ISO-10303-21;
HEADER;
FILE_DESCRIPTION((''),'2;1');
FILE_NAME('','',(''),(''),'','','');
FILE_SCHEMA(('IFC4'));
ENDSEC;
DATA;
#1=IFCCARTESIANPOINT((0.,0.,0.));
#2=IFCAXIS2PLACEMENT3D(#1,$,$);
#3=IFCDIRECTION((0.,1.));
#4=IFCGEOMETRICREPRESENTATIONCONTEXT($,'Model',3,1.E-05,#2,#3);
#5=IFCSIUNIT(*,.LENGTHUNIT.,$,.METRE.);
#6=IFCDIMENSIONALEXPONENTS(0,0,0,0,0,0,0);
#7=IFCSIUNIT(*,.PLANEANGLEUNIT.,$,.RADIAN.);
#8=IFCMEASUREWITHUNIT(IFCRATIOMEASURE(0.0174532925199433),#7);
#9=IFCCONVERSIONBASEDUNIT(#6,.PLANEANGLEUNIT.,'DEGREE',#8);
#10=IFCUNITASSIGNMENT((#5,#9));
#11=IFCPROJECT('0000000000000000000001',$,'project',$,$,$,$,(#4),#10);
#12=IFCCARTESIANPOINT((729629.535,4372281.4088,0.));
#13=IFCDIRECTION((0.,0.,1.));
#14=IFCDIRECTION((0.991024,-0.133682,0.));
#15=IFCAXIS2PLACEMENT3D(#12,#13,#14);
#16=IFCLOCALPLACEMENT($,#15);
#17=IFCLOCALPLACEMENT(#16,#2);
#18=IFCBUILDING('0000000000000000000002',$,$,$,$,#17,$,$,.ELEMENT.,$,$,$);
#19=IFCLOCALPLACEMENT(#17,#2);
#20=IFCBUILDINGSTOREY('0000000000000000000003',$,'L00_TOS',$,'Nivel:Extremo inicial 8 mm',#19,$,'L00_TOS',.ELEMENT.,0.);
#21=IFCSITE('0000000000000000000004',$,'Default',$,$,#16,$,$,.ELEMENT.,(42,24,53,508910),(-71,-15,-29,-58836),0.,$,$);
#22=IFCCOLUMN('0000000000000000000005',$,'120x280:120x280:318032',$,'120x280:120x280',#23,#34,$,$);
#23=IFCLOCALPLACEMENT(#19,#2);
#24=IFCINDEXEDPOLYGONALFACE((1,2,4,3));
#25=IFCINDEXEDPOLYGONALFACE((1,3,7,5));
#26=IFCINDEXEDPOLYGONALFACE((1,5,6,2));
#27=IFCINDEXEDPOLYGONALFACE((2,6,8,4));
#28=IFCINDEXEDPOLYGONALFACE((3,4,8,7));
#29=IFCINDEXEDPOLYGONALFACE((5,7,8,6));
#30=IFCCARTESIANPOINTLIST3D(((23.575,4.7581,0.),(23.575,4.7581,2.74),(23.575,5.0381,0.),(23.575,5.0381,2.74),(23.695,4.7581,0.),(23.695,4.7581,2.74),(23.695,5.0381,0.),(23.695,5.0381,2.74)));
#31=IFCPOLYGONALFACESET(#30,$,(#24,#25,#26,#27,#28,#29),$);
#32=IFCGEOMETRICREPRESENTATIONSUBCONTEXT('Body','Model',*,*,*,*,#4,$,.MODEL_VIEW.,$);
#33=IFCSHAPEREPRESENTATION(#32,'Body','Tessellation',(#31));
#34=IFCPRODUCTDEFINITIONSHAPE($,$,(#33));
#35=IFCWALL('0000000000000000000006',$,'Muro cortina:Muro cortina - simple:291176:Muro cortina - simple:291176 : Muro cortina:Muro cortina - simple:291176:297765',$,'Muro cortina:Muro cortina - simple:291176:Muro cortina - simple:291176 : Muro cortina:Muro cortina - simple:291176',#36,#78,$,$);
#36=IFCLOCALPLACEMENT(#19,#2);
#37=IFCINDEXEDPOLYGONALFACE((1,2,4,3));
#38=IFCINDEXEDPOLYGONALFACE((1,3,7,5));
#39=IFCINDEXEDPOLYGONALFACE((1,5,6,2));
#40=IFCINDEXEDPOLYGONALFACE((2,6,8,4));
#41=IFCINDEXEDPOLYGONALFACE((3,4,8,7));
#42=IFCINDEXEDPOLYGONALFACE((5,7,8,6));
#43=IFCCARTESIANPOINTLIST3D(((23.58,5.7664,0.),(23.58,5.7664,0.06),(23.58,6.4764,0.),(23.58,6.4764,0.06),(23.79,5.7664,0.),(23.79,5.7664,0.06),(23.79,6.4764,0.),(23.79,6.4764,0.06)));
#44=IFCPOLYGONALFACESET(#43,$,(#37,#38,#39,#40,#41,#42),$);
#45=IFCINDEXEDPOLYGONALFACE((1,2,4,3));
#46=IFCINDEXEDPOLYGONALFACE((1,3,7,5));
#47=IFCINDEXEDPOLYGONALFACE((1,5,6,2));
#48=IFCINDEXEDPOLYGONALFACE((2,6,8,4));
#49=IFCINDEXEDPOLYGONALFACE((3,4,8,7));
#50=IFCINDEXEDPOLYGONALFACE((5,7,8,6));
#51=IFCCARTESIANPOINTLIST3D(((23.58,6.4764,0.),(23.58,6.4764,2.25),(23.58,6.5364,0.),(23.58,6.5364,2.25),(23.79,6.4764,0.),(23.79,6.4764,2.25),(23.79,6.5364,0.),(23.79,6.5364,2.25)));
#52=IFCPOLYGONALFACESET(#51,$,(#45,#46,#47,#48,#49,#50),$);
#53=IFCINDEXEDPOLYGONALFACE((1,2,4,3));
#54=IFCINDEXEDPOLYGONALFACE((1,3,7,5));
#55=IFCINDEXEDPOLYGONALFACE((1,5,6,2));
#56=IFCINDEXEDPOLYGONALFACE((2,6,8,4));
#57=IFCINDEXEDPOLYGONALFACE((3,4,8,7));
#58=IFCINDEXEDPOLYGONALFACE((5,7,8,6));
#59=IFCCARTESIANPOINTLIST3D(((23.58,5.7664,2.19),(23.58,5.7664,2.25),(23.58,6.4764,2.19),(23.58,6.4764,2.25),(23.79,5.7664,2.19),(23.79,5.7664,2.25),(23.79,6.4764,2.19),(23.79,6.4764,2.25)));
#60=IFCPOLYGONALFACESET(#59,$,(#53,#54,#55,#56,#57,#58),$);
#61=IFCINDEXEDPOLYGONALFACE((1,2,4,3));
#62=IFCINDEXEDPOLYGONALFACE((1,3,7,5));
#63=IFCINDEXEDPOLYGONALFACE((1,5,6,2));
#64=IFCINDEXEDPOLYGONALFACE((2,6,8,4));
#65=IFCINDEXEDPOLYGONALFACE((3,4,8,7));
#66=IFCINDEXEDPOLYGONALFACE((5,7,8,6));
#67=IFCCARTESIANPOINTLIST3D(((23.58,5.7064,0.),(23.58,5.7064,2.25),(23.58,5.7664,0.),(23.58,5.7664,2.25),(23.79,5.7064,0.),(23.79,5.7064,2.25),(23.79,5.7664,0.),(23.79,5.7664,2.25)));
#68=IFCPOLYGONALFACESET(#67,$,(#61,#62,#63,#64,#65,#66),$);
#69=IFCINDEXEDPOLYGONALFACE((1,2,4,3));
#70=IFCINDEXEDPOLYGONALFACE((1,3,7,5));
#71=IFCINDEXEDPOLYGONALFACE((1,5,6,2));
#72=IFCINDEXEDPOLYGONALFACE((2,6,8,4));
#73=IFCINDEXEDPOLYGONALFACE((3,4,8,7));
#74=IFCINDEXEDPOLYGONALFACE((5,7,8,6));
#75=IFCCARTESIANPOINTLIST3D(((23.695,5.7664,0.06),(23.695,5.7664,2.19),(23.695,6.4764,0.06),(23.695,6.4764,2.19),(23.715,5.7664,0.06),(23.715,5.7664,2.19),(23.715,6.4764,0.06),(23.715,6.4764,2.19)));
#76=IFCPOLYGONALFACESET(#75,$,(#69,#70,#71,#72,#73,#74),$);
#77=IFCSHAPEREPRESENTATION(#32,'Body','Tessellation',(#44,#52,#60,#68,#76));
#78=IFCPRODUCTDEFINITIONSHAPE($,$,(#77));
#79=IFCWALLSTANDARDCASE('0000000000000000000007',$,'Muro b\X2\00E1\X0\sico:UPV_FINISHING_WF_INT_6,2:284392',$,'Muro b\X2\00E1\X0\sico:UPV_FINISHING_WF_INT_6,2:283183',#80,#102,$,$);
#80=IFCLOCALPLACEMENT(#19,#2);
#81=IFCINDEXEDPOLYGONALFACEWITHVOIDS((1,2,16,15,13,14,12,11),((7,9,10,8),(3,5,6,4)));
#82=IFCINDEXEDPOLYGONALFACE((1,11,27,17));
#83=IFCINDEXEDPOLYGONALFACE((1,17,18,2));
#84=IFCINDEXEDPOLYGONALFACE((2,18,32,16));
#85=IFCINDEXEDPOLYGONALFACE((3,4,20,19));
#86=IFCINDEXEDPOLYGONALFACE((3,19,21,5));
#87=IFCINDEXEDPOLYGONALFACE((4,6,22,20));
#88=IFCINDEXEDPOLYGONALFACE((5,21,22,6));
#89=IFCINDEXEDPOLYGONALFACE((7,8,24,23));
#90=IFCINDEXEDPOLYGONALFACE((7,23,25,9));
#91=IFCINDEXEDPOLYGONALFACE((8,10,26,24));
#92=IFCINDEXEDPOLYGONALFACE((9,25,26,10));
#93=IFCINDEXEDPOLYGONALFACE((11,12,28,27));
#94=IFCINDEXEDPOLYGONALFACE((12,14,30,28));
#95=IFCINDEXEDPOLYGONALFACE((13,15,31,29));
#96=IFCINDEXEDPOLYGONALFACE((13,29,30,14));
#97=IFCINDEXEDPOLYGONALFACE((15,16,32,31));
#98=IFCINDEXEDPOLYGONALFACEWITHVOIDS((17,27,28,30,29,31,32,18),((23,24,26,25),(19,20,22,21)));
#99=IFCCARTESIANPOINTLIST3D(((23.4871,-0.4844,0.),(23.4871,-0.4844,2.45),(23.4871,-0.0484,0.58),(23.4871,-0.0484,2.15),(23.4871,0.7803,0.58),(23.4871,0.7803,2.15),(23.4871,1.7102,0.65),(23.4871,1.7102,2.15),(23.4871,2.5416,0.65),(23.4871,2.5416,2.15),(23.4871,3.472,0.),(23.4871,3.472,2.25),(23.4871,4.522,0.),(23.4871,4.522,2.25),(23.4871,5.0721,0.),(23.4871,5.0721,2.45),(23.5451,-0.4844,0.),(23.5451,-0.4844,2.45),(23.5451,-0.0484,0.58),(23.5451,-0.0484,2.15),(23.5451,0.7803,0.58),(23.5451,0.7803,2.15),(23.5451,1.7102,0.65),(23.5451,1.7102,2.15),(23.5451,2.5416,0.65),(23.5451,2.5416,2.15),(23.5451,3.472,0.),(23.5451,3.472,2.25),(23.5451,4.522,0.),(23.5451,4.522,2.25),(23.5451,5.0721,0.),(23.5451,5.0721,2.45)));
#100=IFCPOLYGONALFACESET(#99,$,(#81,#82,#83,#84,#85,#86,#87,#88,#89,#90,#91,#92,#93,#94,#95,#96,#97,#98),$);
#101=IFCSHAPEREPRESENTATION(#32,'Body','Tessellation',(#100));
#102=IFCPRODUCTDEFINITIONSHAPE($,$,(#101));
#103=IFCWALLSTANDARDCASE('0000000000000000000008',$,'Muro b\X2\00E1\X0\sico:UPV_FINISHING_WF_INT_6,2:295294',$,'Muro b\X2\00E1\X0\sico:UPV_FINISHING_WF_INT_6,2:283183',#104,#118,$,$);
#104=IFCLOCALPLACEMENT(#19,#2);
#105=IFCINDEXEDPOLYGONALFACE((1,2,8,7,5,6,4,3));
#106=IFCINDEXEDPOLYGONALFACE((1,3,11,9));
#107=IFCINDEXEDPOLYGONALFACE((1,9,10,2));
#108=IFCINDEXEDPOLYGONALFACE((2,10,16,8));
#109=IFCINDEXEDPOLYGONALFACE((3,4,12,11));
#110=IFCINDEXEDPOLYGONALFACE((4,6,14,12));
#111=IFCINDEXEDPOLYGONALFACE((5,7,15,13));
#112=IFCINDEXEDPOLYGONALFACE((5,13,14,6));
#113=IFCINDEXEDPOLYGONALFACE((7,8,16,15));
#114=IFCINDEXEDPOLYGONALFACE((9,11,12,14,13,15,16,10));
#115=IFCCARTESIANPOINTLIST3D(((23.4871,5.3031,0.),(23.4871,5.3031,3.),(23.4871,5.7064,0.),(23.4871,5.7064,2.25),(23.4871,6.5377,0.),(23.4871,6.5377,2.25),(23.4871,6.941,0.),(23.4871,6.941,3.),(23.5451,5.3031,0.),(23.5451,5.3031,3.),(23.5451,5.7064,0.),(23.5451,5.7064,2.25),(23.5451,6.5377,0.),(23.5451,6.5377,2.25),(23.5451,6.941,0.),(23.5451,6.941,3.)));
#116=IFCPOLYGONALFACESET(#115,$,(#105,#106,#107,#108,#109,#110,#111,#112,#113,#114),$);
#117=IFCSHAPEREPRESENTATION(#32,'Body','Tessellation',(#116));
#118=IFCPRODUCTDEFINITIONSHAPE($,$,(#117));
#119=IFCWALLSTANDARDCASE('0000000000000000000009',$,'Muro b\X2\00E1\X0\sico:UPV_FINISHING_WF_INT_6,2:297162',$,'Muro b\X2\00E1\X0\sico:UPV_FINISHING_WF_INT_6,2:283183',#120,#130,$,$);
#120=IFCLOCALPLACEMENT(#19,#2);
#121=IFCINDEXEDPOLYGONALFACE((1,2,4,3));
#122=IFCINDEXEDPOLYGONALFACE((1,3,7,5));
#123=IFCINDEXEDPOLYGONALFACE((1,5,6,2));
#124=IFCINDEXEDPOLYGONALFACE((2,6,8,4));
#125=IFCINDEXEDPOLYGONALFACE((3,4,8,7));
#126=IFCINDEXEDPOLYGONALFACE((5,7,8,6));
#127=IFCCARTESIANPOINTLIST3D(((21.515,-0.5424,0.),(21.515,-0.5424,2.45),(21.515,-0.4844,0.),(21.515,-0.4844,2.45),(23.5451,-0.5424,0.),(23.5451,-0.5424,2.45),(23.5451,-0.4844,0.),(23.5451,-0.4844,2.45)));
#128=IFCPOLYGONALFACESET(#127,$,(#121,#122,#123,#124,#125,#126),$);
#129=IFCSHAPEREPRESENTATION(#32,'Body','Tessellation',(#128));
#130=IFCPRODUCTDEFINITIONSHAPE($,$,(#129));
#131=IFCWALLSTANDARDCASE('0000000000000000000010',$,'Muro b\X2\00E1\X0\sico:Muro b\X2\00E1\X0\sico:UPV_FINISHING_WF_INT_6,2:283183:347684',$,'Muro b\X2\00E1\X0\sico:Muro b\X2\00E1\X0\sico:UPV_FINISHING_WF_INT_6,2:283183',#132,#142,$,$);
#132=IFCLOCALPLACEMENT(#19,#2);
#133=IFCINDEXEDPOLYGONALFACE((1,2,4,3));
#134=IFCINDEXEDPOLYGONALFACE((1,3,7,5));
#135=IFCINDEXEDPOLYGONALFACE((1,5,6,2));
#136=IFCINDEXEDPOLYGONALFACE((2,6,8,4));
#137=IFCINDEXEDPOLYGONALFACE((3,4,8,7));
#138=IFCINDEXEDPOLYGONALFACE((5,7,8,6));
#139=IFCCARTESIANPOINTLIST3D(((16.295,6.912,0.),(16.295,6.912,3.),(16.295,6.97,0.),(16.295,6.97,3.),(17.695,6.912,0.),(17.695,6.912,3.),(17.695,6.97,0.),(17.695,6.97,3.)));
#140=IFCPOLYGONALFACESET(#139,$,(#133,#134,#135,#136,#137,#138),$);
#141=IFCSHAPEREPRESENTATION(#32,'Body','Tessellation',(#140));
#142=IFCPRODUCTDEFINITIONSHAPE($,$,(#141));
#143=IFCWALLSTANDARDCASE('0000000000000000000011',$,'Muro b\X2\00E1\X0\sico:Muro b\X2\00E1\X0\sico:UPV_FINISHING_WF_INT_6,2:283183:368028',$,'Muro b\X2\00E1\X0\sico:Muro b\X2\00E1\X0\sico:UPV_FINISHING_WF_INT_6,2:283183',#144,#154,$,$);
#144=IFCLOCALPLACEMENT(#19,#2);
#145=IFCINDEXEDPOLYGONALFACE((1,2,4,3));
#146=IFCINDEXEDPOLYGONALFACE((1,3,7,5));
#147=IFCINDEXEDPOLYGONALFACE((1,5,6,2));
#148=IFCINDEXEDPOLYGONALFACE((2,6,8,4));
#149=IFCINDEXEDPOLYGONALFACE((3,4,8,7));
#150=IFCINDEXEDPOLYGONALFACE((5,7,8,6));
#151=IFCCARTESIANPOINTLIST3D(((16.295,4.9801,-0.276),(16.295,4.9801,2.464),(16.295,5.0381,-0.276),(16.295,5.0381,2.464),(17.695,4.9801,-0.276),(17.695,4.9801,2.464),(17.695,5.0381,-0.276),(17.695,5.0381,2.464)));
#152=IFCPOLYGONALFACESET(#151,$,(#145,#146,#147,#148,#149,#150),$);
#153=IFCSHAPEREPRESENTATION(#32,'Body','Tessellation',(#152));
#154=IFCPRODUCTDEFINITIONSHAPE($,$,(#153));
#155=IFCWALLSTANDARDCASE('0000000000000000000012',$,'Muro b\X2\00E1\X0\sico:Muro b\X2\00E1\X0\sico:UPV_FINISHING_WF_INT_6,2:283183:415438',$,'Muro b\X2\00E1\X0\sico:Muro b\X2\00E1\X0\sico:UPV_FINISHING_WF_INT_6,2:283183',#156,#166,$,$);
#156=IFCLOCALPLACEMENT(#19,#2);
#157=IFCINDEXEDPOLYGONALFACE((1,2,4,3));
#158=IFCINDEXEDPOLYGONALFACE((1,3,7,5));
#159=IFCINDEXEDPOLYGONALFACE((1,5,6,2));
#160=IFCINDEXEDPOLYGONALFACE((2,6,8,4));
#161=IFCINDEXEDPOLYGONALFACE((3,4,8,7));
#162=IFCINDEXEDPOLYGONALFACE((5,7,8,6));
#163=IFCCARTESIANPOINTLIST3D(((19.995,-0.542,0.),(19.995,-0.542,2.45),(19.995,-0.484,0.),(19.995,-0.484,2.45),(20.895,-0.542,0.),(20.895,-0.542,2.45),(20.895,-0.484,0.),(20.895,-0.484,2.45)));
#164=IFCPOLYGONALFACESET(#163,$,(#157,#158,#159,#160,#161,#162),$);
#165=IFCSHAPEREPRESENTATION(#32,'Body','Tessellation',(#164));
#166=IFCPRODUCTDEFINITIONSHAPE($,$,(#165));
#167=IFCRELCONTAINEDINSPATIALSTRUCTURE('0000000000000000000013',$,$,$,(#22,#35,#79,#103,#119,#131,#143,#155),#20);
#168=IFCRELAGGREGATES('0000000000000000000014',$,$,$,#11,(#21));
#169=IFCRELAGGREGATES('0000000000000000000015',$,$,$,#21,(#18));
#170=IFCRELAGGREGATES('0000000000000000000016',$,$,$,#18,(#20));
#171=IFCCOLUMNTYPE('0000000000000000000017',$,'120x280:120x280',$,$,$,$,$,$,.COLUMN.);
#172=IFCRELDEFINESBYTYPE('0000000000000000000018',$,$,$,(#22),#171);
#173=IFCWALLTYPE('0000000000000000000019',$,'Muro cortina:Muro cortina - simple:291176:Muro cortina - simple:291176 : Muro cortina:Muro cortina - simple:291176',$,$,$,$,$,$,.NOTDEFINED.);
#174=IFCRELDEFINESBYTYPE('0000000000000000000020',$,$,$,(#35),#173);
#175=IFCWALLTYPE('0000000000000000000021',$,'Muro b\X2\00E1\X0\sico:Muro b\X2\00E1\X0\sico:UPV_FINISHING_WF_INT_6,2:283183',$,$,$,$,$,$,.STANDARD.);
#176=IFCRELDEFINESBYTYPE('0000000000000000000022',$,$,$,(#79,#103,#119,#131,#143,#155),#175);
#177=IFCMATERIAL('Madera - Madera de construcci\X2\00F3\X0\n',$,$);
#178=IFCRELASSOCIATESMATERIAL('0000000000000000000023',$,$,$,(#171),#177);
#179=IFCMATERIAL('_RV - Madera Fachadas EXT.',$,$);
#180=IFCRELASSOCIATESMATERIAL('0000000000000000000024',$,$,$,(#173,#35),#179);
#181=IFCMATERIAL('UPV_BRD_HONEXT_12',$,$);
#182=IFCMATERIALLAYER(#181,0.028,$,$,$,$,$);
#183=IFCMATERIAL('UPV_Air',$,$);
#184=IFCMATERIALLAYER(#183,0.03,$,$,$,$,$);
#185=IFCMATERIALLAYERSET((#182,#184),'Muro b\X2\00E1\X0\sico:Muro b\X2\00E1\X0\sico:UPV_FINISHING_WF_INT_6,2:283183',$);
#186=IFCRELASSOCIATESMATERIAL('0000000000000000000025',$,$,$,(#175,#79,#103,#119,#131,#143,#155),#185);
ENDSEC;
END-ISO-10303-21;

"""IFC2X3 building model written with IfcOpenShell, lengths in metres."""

from ifc_helpers import new_model, entity, si_unit, converted_unit, direction, frame, frame_2d, origin, origin_2d_with_axis, place, context, subcontext, project, spatial, rectangle, extrude, source, transform, mapped, material, layer, layer_set, layer_usage, type_object, type_shapes, element, save


model = new_model("IFC2X3")

# Units and contexts
model_context = context("Model", 3, precision=1e-05, world=origin(), true_north=direction((0.0, 1.0)))
body_context = subcontext(model_context, "Body", "Model", "MODEL_VIEW")
ifc_project = project(units=[si_unit("LENGTHUNIT", "METRE"), converted_unit("PLANEANGLEUNIT", "DEGREE", entity("IfcRatioMeasure", 0.0174532925199433), si_unit("PLANEANGLEUNIT", "RADIAN"), dimensions=[0, 0, 0, 0, 0, 0, 0])], contexts=[model_context])

# Site, building, storey
site_placement = place(None, frame((729629.535, 4372281.4088, 0.0), z_axis=(0.0, 0.0, 1.0), x_axis=(0.991024, -0.133682, 0.0)))
site = spatial("IfcSite", under=ifc_project, at=site_placement, Name="Default", CompositionType="ELEMENT", RefLatitude=(42, 24, 53, 508910), RefLongitude=(-71, -15, -29, -58836), RefElevation=0.0)
building_placement = place(site_placement, origin())
building = spatial("IfcBuilding", under=site, at=building_placement, CompositionType="ELEMENT")
storey_placement = place(building_placement, origin())
storey = spatial("IfcBuildingStorey", under=building, at=storey_placement, Name="L00_TOS", ObjectType="Nivel:Extremo inicial 8 mm", LongName="L00_TOS", CompositionType="ELEMENT", Elevation=0.0)

# Column
ifc_material_1 = material(Name="Madera - Madera de construcción")
column_type = type_object("IfcColumnType", Name="120x280:120x280", PredefinedType="COLUMN", material=ifc_material_1)
shared_shape_1 = source(origin(), body_context, "Body", "SweptSolid", [
    extrude(rectangle(XDim=0.28, YDim=0.12, at=origin_2d_with_axis()), frame((0.0, 0.0, 0.0), z_axis=(0.0, 0.0, 1.0), x_axis=(0.0, -1.0, 0.0)), (0.0, 0.0, 1.0), 2.74),
])
type_shapes(column_type, [shared_shape_1])
column_placement = place(storey_placement, frame((23.635, 4.8981, 0.0)))
element("IfcColumn", 1, at=column_placement, inside=storey, type_object=column_type, Name="120x280:120x280:318032", ObjectType="120x280:120x280", context=body_context, shape_type="MappedRepresentation", body=[
    mapped(shared_shape_1, transform((0.0, 0.0, 0.0), scale=1.0)),
])

# Wall
ifc_material_2 = material(Name="_RV - Madera Fachadas EXT.")
wall_type_1 = type_object("IfcWallType", Name="Muro cortina:Muro cortina - simple:291176:Muro cortina - simple:291176 : Muro cortina:Muro cortina - simple:291176", PredefinedType="NOTDEFINED", material=ifc_material_2)
wall_1_placement = place(storey_placement, frame((23.58, 5.7064, 0.0), z_axis=(0.0, 0.0, 1.0), x_axis=(0.0, 1.0, 0.0)))
element("IfcWall", 2, at=wall_1_placement, inside=storey, type_object=wall_type_1, material=ifc_material_2, Name="Muro cortina:Muro cortina - simple:291176:Muro cortina - simple:291176 : Muro cortina:Muro cortina - simple:291176:297765", ObjectType="Muro cortina:Muro cortina - simple:291176:Muro cortina - simple:291176 : Muro cortina:Muro cortina - simple:291176", context=body_context, shape_type="SweptSolid", body=[
    extrude(rectangle(XDim=0.71, YDim=0.21, at=frame_2d((0.0, 0.0), x_axis=(1.0, 0.0))), frame((0.415, -0.105, 0.0), z_axis=(0.0, 0.0, 1.0), x_axis=(-1.0, 0.0, 0.0)), (0.0, 0.0, 1.0), 0.06),
    extrude(rectangle(XDim=0.06, YDim=0.21, at=frame_2d((0.0, 0.0), x_axis=(1.0, 0.0))), frame((0.8, -0.105, 0.0)), (0.0, 0.0, 1.0), 2.25),
    extrude(rectangle(XDim=0.71, YDim=0.21, at=frame_2d((0.0, 0.0), x_axis=(1.0, 0.0))), frame((0.415, -0.105, 2.19)), (0.0, 0.0, 1.0), 0.06),
    extrude(rectangle(XDim=0.21, YDim=0.06, at=frame_2d((0.0, 0.0), x_axis=(1.0, 0.0))), frame((0.03, -0.105, 0.0), z_axis=(0.0, 0.0, 1.0), x_axis=(0.0, 1.0, 0.0)), (0.0, 0.0, 1.0), 2.25),
    extrude(rectangle(XDim=0.71, YDim=0.02, at=frame_2d((0.0, 0.0), x_axis=(1.0, 0.0))), frame((0.415, -0.125, 0.06)), (0.0, 0.0, 1.0), 2.13),
])

# Wall, openings
ifc_material_3 = material(Name="UPV_BRD_HONEXT_12")
ifc_layer_1 = layer(ifc_material_3, 0.028)
ifc_material_4 = material(Name="UPV_Air")
ifc_layer_2 = layer(ifc_material_4, 0.03)
ifc_layer_set_1 = layer_set([ifc_layer_1, ifc_layer_2], Name="Muro básico:Muro básico:UPV_FINISHING_WF_INT_6,2:283183")
ifc_layer_usage_1 = layer_usage(ifc_layer_set_1, "AXIS2", "NEGATIVE", 0.029)
wall_type_2 = type_object("IfcWallType", Name="Muro básico:Muro básico:UPV_FINISHING_WF_INT_6,2:283183", PredefinedType="STANDARD", material=ifc_layer_set_1)
wall_2_placement = place(storey_placement, frame((23.5161, -0.4844, 0.0), z_axis=(0.0, 0.0, 1.0), x_axis=(0.0, 1.0, 0.0)))
wall_2 = element("IfcWallStandardCase", 3, at=wall_2_placement, inside=storey, type_object=wall_type_2, material=ifc_layer_usage_1, Name="Muro básico:UPV_FINISHING_WF_INT_6,2:284392", ObjectType="Muro básico:UPV_FINISHING_WF_INT_6,2:283183", context=body_context, shape_type="SweptSolid", body=[
    extrude(rectangle(XDim=5.5565, YDim=0.058, at=frame_2d((2.7782, 0.0), x_axis=(-1.0, 0.0))), origin(), (0.0, 0.0, 1.0), 2.45),
])
opening_1_placement = place(wall_2_placement, origin())
element("IfcOpeningElement", 4, at=opening_1_placement, cuts=wall_2, ObjectType="Opening", context=body_context, shape_type="SweptSolid", body=[
    extrude(rectangle(XDim=1.5, YDim=0.8314, at=frame_2d((0.0, 0.0), x_axis=(1.0, 0.0))), frame((2.6103, -0.029, 1.4), z_axis=(0.0, 1.0, 0.0), x_axis=(0.0, 0.0, -1.0)), (0.0, 0.0, 1.0), 0.058),
])
opening_2_placement = place(wall_2_placement, origin())
element("IfcOpeningElement", 5, at=opening_2_placement, cuts=wall_2, ObjectType="Opening", context=body_context, shape_type="SweptSolid", body=[
    extrude(rectangle(XDim=1.57, YDim=0.8287, at=origin_2d_with_axis()), frame((0.8503, -0.029, 1.365), z_axis=(0.0, 1.0, 0.0), x_axis=(0.0, 0.0, -1.0)), (0.0, 0.0, 1.0), 0.058),
])
opening_3_placement = place(wall_2_placement, origin())
element("IfcOpeningElement", 6, at=opening_3_placement, cuts=wall_2, ObjectType="Opening", context=body_context, shape_type="SweptSolid", body=[
    extrude(rectangle(XDim=2.25, YDim=1.05, at=frame_2d((0.0, 0.0), x_axis=(1.0, 0.0))), frame((4.4814, -0.029, 1.125), z_axis=(0.0, 1.0, 0.0), x_axis=(0.0, 0.0, -1.0)), (0.0, 0.0, 1.0), 0.058),
])

# Wall, opening
ifc_layer_usage_2 = layer_usage(ifc_layer_set_1, "AXIS2", "NEGATIVE", 0.029)
wall_3_placement = place(storey_placement, frame((23.5161, 5.3031, 0.0), z_axis=(0.0, 0.0, 1.0), x_axis=(0.0, 1.0, 0.0)))
wall_3 = element("IfcWallStandardCase", 7, at=wall_3_placement, inside=storey, type_object=wall_type_2, material=ifc_layer_usage_2, Name="Muro básico:UPV_FINISHING_WF_INT_6,2:295294", ObjectType="Muro básico:UPV_FINISHING_WF_INT_6,2:283183", context=body_context, shape_type="SweptSolid", body=[
    extrude(rectangle(XDim=1.6379, YDim=0.058, at=frame_2d((0.819, 0.0), x_axis=(-1.0, 0.0))), origin(), (0.0, 0.0, 1.0), 3.0),
])
opening_4_placement = place(wall_3_placement, origin())
element("IfcOpeningElement", 8, at=opening_4_placement, cuts=wall_3, ObjectType="Opening", context=body_context, shape_type="SweptSolid", body=[
    extrude(rectangle(XDim=2.25, YDim=0.8314, at=origin_2d_with_axis()), frame((0.819, -0.029, 1.125), z_axis=(0.0, 1.0, 0.0), x_axis=(0.0, 0.0, -1.0)), (0.0, 0.0, 1.0), 0.058),
])

# Walls
ifc_layer_usage_3 = layer_usage(ifc_layer_set_1, "AXIS2", "NEGATIVE", 0.029)
wall_4_placement = place(storey_placement, frame((21.515, -0.5134, 0.0)))
element("IfcWallStandardCase", 9, at=wall_4_placement, inside=storey, type_object=wall_type_2, material=ifc_layer_usage_3, Name="Muro básico:UPV_FINISHING_WF_INT_6,2:297162", ObjectType="Muro básico:UPV_FINISHING_WF_INT_6,2:283183", context=body_context, shape_type="SweptSolid", body=[
    extrude(rectangle(XDim=2.0301, YDim=0.058, at=frame_2d((1.0151, 0.0), x_axis=(-1.0, 0.0))), origin(), (0.0, 0.0, 1.0), 2.45),
])
ifc_layer_usage_4 = layer_usage(ifc_layer_set_1, "AXIS2", "NEGATIVE", 0.029)
wall_5_placement = place(storey_placement, frame((17.695, 6.941, 0.0), z_axis=(0.0, 0.0, 1.0), x_axis=(-1.0, 0.0, 0.0)))
element("IfcWallStandardCase", 10, at=wall_5_placement, inside=storey, type_object=wall_type_2, material=ifc_layer_usage_4, Name="Muro básico:Muro básico:UPV_FINISHING_WF_INT_6,2:283183:347684", ObjectType="Muro básico:Muro básico:UPV_FINISHING_WF_INT_6,2:283183", context=body_context, shape_type="SweptSolid", body=[
    extrude(rectangle(XDim=1.4, YDim=0.058, at=frame_2d((0.7, 0.0), x_axis=(-1.0, 0.0))), origin(), (0.0, 0.0, 1.0), 3.0),
])
ifc_layer_usage_5 = layer_usage(ifc_layer_set_1, "AXIS2", "NEGATIVE", 0.029)
wall_6_placement = place(storey_placement, frame((17.695, 5.0091, -0.276), z_axis=(0.0, 0.0, 1.0), x_axis=(-1.0, 0.0, 0.0)))
element("IfcWallStandardCase", 11, at=wall_6_placement, inside=storey, type_object=wall_type_2, material=ifc_layer_usage_5, Name="Muro básico:Muro básico:UPV_FINISHING_WF_INT_6,2:283183:368028", ObjectType="Muro básico:Muro básico:UPV_FINISHING_WF_INT_6,2:283183", context=body_context, shape_type="SweptSolid", body=[
    extrude(rectangle(XDim=1.4, YDim=0.058, at=frame_2d((0.7, 0.0), x_axis=(-1.0, 0.0))), origin(), (0.0, 0.0, 1.0), 2.74),
])
ifc_layer_usage_6 = layer_usage(ifc_layer_set_1, "AXIS2", "NEGATIVE", 0.029)
wall_7_placement = place(storey_placement, frame((19.995, -0.513, 0.0)))
element("IfcWallStandardCase", 12, at=wall_7_placement, inside=storey, type_object=wall_type_2, material=ifc_layer_usage_6, Name="Muro básico:Muro básico:UPV_FINISHING_WF_INT_6,2:283183:415438", ObjectType="Muro básico:Muro básico:UPV_FINISHING_WF_INT_6,2:283183", context=body_context, shape_type="SweptSolid", body=[
    extrude(rectangle(XDim=0.9, YDim=0.058, at=frame_2d((0.45, 0.0), x_axis=(-1.0, 0.0))), origin(), (0.0, 0.0, 1.0), 2.45),
])

save(model, "model.ifc")
